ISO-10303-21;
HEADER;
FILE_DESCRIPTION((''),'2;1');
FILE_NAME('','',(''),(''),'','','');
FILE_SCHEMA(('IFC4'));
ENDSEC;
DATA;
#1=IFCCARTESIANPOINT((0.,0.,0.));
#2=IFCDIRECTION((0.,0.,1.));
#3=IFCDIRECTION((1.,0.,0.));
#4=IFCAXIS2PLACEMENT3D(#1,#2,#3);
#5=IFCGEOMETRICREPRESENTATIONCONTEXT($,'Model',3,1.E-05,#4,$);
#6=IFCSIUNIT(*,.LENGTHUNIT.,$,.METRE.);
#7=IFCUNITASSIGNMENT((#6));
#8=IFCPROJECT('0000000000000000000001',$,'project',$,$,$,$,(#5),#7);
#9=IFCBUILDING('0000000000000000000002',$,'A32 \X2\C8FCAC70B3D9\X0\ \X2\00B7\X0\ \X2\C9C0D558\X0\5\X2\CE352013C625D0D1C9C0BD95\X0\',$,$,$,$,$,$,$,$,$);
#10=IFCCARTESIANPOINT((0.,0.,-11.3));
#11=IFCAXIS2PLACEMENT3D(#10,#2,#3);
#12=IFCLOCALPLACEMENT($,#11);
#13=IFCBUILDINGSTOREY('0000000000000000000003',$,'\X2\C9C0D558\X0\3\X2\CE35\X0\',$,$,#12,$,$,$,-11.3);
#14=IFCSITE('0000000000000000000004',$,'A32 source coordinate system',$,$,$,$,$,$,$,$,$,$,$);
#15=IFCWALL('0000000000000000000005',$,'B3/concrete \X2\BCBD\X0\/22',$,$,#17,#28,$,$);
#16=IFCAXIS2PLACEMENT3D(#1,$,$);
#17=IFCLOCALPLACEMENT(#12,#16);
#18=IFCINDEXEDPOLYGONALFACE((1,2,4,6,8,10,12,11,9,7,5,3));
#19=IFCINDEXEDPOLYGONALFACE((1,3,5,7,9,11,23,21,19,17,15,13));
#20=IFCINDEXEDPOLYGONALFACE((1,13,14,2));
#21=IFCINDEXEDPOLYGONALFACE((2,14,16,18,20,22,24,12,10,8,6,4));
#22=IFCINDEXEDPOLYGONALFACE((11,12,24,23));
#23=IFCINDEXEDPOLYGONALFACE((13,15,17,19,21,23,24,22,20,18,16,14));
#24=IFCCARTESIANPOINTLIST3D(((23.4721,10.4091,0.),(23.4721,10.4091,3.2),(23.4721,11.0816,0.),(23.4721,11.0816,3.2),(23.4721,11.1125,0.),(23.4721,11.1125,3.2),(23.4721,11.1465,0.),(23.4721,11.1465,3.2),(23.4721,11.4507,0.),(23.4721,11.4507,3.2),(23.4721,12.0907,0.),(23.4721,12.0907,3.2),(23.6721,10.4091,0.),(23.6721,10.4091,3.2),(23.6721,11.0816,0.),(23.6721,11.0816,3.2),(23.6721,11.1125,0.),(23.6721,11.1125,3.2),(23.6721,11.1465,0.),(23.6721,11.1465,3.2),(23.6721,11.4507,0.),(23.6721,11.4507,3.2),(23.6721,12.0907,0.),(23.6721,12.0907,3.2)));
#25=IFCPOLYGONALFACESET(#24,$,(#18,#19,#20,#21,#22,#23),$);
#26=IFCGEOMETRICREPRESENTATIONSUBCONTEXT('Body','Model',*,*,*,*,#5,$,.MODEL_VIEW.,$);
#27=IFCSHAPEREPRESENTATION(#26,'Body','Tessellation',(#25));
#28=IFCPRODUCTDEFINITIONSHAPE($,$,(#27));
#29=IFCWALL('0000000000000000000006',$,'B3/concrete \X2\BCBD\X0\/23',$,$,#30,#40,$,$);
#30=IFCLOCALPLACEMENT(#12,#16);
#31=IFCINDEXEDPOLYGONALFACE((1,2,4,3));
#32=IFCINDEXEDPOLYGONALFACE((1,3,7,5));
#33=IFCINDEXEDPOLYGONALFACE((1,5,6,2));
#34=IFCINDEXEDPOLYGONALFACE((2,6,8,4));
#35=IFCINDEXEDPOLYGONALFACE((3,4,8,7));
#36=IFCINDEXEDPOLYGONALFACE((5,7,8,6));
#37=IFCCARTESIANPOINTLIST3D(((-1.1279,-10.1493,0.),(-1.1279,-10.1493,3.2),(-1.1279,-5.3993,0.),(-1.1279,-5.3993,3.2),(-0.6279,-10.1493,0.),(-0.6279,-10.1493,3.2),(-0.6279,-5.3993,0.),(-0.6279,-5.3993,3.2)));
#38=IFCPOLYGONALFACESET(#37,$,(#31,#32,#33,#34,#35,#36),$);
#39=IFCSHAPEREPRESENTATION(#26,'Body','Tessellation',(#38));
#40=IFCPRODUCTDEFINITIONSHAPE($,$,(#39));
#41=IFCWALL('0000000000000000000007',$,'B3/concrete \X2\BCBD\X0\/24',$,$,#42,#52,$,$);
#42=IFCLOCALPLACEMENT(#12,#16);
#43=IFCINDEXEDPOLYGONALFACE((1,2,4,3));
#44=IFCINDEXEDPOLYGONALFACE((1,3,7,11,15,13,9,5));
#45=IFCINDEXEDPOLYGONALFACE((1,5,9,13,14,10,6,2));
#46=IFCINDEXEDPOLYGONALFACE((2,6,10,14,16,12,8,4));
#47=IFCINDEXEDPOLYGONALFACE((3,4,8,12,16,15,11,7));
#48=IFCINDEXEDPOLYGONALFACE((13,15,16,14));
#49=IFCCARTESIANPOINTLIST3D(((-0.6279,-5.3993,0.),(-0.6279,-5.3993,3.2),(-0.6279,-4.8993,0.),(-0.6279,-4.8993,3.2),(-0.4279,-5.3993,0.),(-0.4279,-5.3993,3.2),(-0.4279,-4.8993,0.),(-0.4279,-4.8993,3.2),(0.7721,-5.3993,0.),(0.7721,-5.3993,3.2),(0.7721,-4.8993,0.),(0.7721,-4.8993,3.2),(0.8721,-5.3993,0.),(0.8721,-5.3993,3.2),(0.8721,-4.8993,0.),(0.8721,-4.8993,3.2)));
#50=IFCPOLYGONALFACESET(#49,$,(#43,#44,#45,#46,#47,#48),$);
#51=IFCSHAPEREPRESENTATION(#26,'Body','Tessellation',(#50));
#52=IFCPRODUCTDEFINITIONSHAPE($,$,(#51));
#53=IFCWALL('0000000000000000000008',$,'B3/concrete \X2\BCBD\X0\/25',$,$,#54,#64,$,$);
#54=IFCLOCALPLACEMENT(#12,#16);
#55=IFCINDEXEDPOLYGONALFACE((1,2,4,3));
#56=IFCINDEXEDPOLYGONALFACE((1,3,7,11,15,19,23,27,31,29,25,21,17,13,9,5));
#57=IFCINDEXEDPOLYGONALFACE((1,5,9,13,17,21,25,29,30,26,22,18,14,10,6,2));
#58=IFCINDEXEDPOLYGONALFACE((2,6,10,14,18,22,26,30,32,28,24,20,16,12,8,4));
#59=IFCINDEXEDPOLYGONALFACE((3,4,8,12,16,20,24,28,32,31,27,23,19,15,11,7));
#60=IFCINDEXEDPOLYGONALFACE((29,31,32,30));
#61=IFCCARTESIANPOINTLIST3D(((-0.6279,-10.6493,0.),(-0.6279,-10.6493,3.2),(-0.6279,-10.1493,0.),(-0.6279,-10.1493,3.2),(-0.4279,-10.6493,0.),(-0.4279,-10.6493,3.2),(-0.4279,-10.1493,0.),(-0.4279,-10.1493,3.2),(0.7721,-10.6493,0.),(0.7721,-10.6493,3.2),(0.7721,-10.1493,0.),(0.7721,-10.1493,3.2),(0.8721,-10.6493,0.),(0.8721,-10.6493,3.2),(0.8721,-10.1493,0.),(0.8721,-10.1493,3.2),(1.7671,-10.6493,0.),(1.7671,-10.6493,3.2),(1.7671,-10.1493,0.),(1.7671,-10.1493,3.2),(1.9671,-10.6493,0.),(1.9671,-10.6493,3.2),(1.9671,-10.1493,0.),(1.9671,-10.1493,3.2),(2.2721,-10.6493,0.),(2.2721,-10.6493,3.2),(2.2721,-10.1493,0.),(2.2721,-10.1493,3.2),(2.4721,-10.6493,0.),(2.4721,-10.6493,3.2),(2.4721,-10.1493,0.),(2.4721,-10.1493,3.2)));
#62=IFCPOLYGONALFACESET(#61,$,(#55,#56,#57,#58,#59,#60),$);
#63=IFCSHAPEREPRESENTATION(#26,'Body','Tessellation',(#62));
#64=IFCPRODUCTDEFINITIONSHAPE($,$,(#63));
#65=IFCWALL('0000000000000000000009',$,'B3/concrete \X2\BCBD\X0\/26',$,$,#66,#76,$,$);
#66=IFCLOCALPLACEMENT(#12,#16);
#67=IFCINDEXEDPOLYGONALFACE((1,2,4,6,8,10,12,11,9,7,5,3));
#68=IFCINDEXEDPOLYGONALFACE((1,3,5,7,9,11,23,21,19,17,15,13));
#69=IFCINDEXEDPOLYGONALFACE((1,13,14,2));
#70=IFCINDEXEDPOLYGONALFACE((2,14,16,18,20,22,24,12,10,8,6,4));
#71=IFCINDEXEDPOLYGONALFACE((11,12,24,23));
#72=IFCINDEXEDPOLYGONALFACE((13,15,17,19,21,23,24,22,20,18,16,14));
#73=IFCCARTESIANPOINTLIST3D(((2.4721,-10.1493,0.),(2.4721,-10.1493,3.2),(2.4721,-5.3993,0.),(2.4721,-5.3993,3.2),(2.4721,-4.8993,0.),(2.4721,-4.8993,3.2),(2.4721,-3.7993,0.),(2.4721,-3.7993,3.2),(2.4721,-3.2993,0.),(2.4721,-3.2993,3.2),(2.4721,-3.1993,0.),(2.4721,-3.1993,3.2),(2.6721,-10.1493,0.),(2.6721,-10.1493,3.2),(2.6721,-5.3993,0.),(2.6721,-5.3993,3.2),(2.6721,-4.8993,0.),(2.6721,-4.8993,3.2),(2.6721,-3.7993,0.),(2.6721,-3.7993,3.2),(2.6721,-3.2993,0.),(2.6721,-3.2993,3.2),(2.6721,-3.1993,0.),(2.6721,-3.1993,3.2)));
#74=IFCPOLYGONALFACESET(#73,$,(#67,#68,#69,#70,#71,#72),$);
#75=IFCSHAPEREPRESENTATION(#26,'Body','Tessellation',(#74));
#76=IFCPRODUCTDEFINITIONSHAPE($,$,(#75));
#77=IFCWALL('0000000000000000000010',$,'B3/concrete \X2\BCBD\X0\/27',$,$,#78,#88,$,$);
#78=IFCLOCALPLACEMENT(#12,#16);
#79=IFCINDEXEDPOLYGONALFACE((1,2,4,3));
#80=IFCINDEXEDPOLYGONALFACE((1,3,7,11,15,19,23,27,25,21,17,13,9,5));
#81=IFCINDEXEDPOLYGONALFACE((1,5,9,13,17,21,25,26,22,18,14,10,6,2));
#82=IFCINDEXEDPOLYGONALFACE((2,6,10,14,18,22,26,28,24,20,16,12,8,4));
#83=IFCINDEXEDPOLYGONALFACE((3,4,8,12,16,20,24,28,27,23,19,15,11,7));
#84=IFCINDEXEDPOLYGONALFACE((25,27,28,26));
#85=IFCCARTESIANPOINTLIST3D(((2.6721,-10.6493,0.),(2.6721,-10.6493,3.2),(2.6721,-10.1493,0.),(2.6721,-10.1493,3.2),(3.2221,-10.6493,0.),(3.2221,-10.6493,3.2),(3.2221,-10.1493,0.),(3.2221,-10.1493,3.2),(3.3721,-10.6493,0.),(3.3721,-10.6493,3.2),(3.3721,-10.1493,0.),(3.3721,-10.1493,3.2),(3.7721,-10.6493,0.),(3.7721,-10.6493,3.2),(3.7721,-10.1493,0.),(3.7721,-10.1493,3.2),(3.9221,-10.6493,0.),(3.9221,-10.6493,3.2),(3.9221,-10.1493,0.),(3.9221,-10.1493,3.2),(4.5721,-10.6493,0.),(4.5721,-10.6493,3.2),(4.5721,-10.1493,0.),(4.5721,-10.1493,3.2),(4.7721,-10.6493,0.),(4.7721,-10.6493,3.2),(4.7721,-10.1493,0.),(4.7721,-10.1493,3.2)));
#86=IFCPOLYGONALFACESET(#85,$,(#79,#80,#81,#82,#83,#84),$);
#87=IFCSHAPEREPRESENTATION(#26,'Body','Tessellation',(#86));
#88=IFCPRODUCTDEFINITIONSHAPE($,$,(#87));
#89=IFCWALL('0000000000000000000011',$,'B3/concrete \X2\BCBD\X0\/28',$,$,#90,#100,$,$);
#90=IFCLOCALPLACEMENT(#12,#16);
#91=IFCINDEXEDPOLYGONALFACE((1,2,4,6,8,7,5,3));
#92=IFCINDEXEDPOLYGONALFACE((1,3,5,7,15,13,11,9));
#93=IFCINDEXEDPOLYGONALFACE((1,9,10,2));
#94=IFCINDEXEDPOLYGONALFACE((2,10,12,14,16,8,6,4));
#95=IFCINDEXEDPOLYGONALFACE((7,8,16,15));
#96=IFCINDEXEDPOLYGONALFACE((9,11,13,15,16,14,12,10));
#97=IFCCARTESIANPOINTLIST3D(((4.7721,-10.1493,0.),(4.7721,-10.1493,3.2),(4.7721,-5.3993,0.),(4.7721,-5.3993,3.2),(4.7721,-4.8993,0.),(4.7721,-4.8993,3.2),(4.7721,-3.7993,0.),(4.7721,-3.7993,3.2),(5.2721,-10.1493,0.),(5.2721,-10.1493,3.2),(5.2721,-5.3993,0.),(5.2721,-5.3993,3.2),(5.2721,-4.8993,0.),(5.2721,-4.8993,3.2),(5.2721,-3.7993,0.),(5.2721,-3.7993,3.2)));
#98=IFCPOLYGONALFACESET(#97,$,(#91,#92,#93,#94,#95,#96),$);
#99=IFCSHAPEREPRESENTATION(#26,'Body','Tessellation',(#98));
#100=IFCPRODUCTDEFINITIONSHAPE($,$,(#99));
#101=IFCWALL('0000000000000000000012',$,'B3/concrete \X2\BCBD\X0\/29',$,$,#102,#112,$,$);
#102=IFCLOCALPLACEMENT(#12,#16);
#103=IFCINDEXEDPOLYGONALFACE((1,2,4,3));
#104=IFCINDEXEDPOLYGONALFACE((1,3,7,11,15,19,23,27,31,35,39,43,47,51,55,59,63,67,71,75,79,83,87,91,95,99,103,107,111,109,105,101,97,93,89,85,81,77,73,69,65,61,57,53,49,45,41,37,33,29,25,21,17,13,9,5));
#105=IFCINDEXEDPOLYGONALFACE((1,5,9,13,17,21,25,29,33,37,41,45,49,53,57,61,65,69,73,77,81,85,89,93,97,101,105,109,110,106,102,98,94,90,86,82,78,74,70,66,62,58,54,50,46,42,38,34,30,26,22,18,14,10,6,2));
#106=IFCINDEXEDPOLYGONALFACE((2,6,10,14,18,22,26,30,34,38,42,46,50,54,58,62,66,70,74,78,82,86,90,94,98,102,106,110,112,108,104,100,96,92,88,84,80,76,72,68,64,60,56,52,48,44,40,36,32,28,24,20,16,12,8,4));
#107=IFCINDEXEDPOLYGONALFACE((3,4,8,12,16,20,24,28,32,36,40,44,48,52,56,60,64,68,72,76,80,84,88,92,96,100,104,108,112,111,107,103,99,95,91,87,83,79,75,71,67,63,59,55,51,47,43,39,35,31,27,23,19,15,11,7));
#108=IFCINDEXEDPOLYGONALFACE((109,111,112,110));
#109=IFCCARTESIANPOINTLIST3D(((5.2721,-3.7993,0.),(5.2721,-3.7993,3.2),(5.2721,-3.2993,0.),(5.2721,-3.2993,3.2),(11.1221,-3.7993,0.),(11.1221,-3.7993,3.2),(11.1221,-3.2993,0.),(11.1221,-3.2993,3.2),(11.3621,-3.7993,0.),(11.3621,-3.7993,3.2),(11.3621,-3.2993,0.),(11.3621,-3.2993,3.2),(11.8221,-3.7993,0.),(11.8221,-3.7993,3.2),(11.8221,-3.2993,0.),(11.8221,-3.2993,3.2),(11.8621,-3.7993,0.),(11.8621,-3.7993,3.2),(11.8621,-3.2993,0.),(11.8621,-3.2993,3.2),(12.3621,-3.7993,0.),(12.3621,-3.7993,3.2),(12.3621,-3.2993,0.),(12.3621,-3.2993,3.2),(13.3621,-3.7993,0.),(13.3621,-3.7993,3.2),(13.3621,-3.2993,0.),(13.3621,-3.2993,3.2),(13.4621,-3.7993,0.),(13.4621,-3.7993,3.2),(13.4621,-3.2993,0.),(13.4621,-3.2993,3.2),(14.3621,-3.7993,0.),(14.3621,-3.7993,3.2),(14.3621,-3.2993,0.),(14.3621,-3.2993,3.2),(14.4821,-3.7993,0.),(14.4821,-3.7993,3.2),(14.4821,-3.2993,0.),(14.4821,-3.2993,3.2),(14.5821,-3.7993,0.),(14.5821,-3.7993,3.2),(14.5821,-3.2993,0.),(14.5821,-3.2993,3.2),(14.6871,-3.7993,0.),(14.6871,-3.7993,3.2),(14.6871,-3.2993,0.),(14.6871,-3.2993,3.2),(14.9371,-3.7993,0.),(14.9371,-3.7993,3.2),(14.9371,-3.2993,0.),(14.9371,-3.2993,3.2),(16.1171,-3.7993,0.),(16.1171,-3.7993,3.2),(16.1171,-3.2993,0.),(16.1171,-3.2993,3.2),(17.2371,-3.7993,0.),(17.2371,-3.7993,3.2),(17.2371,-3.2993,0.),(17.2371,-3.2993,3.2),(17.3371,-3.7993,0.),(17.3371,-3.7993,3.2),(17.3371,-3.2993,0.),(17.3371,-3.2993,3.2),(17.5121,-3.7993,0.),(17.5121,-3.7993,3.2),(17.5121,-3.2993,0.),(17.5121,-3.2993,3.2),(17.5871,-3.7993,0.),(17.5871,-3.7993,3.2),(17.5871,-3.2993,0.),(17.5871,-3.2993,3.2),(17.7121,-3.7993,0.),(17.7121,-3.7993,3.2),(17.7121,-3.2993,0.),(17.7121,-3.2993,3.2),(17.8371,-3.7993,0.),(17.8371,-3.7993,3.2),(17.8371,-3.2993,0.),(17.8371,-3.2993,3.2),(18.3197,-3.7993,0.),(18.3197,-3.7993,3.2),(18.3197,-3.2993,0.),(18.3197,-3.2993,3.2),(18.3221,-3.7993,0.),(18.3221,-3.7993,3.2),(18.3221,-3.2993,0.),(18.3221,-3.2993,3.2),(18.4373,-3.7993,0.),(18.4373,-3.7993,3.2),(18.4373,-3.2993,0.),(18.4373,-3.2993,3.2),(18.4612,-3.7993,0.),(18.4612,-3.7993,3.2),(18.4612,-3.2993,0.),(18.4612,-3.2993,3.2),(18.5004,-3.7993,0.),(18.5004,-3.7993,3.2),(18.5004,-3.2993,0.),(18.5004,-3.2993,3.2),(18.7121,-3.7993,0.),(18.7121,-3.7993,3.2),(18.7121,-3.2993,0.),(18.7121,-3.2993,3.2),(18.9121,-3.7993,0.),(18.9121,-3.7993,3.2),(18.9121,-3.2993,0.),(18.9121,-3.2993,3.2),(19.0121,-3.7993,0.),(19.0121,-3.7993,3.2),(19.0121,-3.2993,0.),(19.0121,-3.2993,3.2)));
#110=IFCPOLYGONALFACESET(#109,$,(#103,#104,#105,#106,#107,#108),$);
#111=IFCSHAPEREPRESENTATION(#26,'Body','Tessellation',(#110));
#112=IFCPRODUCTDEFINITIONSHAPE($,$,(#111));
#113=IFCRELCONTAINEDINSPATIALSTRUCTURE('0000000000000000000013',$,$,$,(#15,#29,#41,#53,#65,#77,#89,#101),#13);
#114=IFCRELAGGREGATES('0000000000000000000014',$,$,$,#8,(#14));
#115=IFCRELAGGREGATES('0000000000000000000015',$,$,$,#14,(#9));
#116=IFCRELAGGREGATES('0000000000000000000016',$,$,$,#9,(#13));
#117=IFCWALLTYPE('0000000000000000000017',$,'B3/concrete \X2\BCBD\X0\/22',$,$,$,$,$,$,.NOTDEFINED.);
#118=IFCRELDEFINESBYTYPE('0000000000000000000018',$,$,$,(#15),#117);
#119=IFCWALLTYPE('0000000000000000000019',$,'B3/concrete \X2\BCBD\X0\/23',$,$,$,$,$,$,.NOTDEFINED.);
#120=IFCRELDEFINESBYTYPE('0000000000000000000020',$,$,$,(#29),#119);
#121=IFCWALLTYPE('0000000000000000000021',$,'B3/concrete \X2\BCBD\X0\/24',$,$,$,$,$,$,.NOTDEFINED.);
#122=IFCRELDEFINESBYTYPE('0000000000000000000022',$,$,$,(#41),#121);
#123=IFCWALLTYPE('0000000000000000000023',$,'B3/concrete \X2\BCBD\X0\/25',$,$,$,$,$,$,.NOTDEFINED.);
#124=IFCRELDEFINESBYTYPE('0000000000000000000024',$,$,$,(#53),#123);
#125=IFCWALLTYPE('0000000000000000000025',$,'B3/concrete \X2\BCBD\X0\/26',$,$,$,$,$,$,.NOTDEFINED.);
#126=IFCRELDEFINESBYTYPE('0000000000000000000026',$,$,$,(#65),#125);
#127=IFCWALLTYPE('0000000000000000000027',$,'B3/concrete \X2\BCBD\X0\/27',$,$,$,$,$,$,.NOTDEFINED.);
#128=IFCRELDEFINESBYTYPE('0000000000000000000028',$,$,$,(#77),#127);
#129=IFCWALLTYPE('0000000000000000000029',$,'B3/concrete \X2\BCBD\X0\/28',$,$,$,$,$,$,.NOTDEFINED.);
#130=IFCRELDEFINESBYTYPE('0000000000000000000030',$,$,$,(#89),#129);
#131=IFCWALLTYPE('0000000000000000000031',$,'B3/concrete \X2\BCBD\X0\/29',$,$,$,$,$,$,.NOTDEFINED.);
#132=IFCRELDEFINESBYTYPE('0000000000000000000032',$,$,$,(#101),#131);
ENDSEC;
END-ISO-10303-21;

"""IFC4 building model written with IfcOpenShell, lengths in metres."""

from ifc_helpers import new_model, si_unit, frame, origin, origin_with_axes, place, context, subcontext, project, spatial, polyline, outline, extrude, source, transform, mapped, type_object, type_shapes, element, save


model = new_model("IFC4")

# Units and contexts
model_context = context("Model", 3, precision=1e-05, world=origin_with_axes())
body_context = subcontext(model_context, "Body", "Model", "MODEL_VIEW")
ifc_project = project(units=[si_unit("LENGTHUNIT", "METRE")], contexts=[model_context])

# Site, building, storey
site = spatial("IfcSite", under=ifc_project, Name="A32 source coordinate system")
building = spatial("IfcBuilding", under=site, Name="A32 주거동 · 지하5층–옥탑지붕")
storey_placement = place(None, frame((0.0, 0.0, -11.3), z_axis=(0.0, 0.0, 1.0), x_axis=(1.0, 0.0, 0.0)))
storey = spatial("IfcBuildingStorey", under=building, at=storey_placement, Name="지하3층", Elevation=-11.3)

# Walls
wall_type_1 = type_object("IfcWallType", Name="B3/concrete 벽/22", PredefinedType="NOTDEFINED")
shared_shape_1 = source(origin(), body_context, "Body", "SweptSolid", [
    extrude(outline(polyline([(23.6721, 11.0816), (23.6721, 10.4091), (23.4721, 10.4091), (23.4721, 11.0816), (23.4721, 11.1125), (23.4721, 11.1465), (23.4721, 11.4507), (23.4721, 12.0907), (23.6721, 12.0907), (23.6721, 11.4507), (23.6721, 11.1465), (23.6721, 11.1125), (23.6721, 11.0816)])), origin(), (0.0, 0.0, 1.0), 3.2),
])
type_shapes(wall_type_1, [shared_shape_1])
wall_1_placement = place(storey_placement, origin_with_axes())
element("IfcWall", 1, at=wall_1_placement, inside=storey, type_object=wall_type_1, Name="B3/concrete 벽/22", context=body_context, shape_type="MappedRepresentation", body=[
    mapped(shared_shape_1, transform((0.0, 0.0, 0.0), scale=1.0)),
])
wall_type_2 = type_object("IfcWallType", Name="B3/concrete 벽/23", PredefinedType="NOTDEFINED")
shared_shape_2 = source(origin(), body_context, "Body", "SweptSolid", [
    extrude(outline(polyline([(-0.6279, -10.1493), (-1.1279, -10.1493), (-1.1279, -5.3993), (-0.6279, -5.3993), (-0.6279, -10.1493)])), origin(), (0.0, 0.0, 1.0), 3.2),
])
type_shapes(wall_type_2, [shared_shape_2])
wall_2_placement = place(storey_placement, origin_with_axes())
element("IfcWall", 2, at=wall_2_placement, inside=storey, type_object=wall_type_2, Name="B3/concrete 벽/23", context=body_context, shape_type="MappedRepresentation", body=[
    mapped(shared_shape_2, transform((0.0, 0.0, 0.0), scale=1.0)),
])
wall_type_3 = type_object("IfcWallType", Name="B3/concrete 벽/24", PredefinedType="NOTDEFINED")
shared_shape_3 = source(origin(), body_context, "Body", "SweptSolid", [
    extrude(outline(polyline([(0.7721, -4.8993), (0.8721, -4.8993), (0.8721, -5.3993), (0.7721, -5.3993), (-0.4279, -5.3993), (-0.6279, -5.3993), (-0.6279, -4.8993), (-0.4279, -4.8993), (0.7721, -4.8993)])), origin(), (0.0, 0.0, 1.0), 3.2),
])
type_shapes(wall_type_3, [shared_shape_3])
wall_3_placement = place(storey_placement, origin_with_axes())
element("IfcWall", 3, at=wall_3_placement, inside=storey, type_object=wall_type_3, Name="B3/concrete 벽/24", context=body_context, shape_type="MappedRepresentation", body=[
    mapped(shared_shape_3, transform((0.0, 0.0, 0.0), scale=1.0)),
])
wall_type_4 = type_object("IfcWallType", Name="B3/concrete 벽/25", PredefinedType="NOTDEFINED")
shared_shape_4 = source(origin(), body_context, "Body", "SweptSolid", [
    extrude(outline(polyline([(0.8721, -10.1493), (1.7671, -10.1493), (1.9671, -10.1493), (2.2721, -10.1493), (2.4721, -10.1493), (2.4721, -10.6493), (2.2721, -10.6493), (1.9671, -10.6493), (1.7671, -10.6493), (0.8721, -10.6493), (0.7721, -10.6493), (-0.4279, -10.6493), (-0.6279, -10.6493), (-0.6279, -10.1493), (-0.4279, -10.1493), (0.7721, -10.1493), (0.8721, -10.1493)])), origin(), (0.0, 0.0, 1.0), 3.2),
])
type_shapes(wall_type_4, [shared_shape_4])
wall_4_placement = place(storey_placement, origin_with_axes())
element("IfcWall", 4, at=wall_4_placement, inside=storey, type_object=wall_type_4, Name="B3/concrete 벽/25", context=body_context, shape_type="MappedRepresentation", body=[
    mapped(shared_shape_4, transform((0.0, 0.0, 0.0), scale=1.0)),
])
wall_type_5 = type_object("IfcWallType", Name="B3/concrete 벽/26", PredefinedType="NOTDEFINED")
shared_shape_5 = source(origin(), body_context, "Body", "SweptSolid", [
    extrude(outline(polyline([(2.4721, -3.7993), (2.4721, -3.2993), (2.4721, -3.1993), (2.6721, -3.1993), (2.6721, -3.2993), (2.6721, -3.7993), (2.6721, -4.8993), (2.6721, -5.3993), (2.6721, -10.1493), (2.4721, -10.1493), (2.4721, -5.3993), (2.4721, -4.8993), (2.4721, -3.7993)])), origin(), (0.0, 0.0, 1.0), 3.2),
])
type_shapes(wall_type_5, [shared_shape_5])
wall_5_placement = place(storey_placement, origin_with_axes())
element("IfcWall", 5, at=wall_5_placement, inside=storey, type_object=wall_type_5, Name="B3/concrete 벽/26", context=body_context, shape_type="MappedRepresentation", body=[
    mapped(shared_shape_5, transform((0.0, 0.0, 0.0), scale=1.0)),
])
wall_type_6 = type_object("IfcWallType", Name="B3/concrete 벽/27", PredefinedType="NOTDEFINED")
shared_shape_6 = source(origin(), body_context, "Body", "SweptSolid", [
    extrude(outline(polyline([(3.7721, -10.1493), (3.9221, -10.1493), (4.5721, -10.1493), (4.7721, -10.1493), (4.7721, -10.6493), (4.5721, -10.6493), (3.9221, -10.6493), (3.7721, -10.6493), (3.3721, -10.6493), (3.2221, -10.6493), (2.6721, -10.6493), (2.6721, -10.1493), (3.2221, -10.1493), (3.3721, -10.1493), (3.7721, -10.1493)])), origin(), (0.0, 0.0, 1.0), 3.2),
])
type_shapes(wall_type_6, [shared_shape_6])
wall_6_placement = place(storey_placement, origin_with_axes())
element("IfcWall", 6, at=wall_6_placement, inside=storey, type_object=wall_type_6, Name="B3/concrete 벽/27", context=body_context, shape_type="MappedRepresentation", body=[
    mapped(shared_shape_6, transform((0.0, 0.0, 0.0), scale=1.0)),
])
wall_type_7 = type_object("IfcWallType", Name="B3/concrete 벽/28", PredefinedType="NOTDEFINED")
shared_shape_7 = source(origin(), body_context, "Body", "SweptSolid", [
    extrude(outline(polyline([(4.7721, -3.7993), (5.2721, -3.7993), (5.2721, -4.8993), (5.2721, -5.3993), (5.2721, -10.1493), (4.7721, -10.1493), (4.7721, -5.3993), (4.7721, -4.8993), (4.7721, -3.7993)])), origin(), (0.0, 0.0, 1.0), 3.2),
])
type_shapes(wall_type_7, [shared_shape_7])
wall_7_placement = place(storey_placement, origin_with_axes())
element("IfcWall", 7, at=wall_7_placement, inside=storey, type_object=wall_type_7, Name="B3/concrete 벽/28", context=body_context, shape_type="MappedRepresentation", body=[
    mapped(shared_shape_7, transform((0.0, 0.0, 0.0), scale=1.0)),
])
wall_type_8 = type_object("IfcWallType", Name="B3/concrete 벽/29", PredefinedType="NOTDEFINED")
shared_shape_8 = source(origin(), body_context, "Body", "SweptSolid", [
    extrude(outline(polyline([(11.3621, -3.2993), (11.8221, -3.2993), (11.8621, -3.2993), (12.3621, -3.2993), (13.3621, -3.2993), (13.4621, -3.2993), (14.3621, -3.2993), (14.4821, -3.2993), (14.5821, -3.2993), (14.6871, -3.2993), (14.9371, -3.2993), (16.1171, -3.2993), (17.2371, -3.2993), (17.3371, -3.2993), (17.5121, -3.2993), (17.5871, -3.2993), (17.7121, -3.2993), (17.8371, -3.2993), (18.3197, -3.2993), (18.3221, -3.2993), (18.4373, -3.2993), (18.4612, -3.2993), (18.5004, -3.2993), (18.7121, -3.2993), (18.9121, -3.2993), (19.0121, -3.2993), (19.0121, -3.7993), (18.9121, -3.7993), (18.7121, -3.7993), (18.5004, -3.7993), (18.4612, -3.7993), (18.4373, -3.7993), (18.3221, -3.7993), (18.3197, -3.7993), (17.8371, -3.7993), (17.7121, -3.7993), (17.5871, -3.7993), (17.5121, -3.7993), (17.3371, -3.7993), (17.2371, -3.7993), (16.1171, -3.7993), (14.9371, -3.7993), (14.6871, -3.7993), (14.5821, -3.7993), (14.4821, -3.7993), (14.3621, -3.7993), (13.4621, -3.7993), (13.3621, -3.7993), (12.3621, -3.7993), (11.8621, -3.7993), (11.8221, -3.7993), (11.3621, -3.7993), (11.1221, -3.7993), (5.2721, -3.7993), (5.2721, -3.2993), (11.1221, -3.2993), (11.3621, -3.2993)])), origin(), (0.0, 0.0, 1.0), 3.2),
])
type_shapes(wall_type_8, [shared_shape_8])
wall_8_placement = place(storey_placement, origin_with_axes())
element("IfcWall", 8, at=wall_8_placement, inside=storey, type_object=wall_type_8, Name="B3/concrete 벽/29", context=body_context, shape_type="MappedRepresentation", body=[
    mapped(shared_shape_8, transform((0.0, 0.0, 0.0), scale=1.0)),
])

save(model, "model.ifc")
